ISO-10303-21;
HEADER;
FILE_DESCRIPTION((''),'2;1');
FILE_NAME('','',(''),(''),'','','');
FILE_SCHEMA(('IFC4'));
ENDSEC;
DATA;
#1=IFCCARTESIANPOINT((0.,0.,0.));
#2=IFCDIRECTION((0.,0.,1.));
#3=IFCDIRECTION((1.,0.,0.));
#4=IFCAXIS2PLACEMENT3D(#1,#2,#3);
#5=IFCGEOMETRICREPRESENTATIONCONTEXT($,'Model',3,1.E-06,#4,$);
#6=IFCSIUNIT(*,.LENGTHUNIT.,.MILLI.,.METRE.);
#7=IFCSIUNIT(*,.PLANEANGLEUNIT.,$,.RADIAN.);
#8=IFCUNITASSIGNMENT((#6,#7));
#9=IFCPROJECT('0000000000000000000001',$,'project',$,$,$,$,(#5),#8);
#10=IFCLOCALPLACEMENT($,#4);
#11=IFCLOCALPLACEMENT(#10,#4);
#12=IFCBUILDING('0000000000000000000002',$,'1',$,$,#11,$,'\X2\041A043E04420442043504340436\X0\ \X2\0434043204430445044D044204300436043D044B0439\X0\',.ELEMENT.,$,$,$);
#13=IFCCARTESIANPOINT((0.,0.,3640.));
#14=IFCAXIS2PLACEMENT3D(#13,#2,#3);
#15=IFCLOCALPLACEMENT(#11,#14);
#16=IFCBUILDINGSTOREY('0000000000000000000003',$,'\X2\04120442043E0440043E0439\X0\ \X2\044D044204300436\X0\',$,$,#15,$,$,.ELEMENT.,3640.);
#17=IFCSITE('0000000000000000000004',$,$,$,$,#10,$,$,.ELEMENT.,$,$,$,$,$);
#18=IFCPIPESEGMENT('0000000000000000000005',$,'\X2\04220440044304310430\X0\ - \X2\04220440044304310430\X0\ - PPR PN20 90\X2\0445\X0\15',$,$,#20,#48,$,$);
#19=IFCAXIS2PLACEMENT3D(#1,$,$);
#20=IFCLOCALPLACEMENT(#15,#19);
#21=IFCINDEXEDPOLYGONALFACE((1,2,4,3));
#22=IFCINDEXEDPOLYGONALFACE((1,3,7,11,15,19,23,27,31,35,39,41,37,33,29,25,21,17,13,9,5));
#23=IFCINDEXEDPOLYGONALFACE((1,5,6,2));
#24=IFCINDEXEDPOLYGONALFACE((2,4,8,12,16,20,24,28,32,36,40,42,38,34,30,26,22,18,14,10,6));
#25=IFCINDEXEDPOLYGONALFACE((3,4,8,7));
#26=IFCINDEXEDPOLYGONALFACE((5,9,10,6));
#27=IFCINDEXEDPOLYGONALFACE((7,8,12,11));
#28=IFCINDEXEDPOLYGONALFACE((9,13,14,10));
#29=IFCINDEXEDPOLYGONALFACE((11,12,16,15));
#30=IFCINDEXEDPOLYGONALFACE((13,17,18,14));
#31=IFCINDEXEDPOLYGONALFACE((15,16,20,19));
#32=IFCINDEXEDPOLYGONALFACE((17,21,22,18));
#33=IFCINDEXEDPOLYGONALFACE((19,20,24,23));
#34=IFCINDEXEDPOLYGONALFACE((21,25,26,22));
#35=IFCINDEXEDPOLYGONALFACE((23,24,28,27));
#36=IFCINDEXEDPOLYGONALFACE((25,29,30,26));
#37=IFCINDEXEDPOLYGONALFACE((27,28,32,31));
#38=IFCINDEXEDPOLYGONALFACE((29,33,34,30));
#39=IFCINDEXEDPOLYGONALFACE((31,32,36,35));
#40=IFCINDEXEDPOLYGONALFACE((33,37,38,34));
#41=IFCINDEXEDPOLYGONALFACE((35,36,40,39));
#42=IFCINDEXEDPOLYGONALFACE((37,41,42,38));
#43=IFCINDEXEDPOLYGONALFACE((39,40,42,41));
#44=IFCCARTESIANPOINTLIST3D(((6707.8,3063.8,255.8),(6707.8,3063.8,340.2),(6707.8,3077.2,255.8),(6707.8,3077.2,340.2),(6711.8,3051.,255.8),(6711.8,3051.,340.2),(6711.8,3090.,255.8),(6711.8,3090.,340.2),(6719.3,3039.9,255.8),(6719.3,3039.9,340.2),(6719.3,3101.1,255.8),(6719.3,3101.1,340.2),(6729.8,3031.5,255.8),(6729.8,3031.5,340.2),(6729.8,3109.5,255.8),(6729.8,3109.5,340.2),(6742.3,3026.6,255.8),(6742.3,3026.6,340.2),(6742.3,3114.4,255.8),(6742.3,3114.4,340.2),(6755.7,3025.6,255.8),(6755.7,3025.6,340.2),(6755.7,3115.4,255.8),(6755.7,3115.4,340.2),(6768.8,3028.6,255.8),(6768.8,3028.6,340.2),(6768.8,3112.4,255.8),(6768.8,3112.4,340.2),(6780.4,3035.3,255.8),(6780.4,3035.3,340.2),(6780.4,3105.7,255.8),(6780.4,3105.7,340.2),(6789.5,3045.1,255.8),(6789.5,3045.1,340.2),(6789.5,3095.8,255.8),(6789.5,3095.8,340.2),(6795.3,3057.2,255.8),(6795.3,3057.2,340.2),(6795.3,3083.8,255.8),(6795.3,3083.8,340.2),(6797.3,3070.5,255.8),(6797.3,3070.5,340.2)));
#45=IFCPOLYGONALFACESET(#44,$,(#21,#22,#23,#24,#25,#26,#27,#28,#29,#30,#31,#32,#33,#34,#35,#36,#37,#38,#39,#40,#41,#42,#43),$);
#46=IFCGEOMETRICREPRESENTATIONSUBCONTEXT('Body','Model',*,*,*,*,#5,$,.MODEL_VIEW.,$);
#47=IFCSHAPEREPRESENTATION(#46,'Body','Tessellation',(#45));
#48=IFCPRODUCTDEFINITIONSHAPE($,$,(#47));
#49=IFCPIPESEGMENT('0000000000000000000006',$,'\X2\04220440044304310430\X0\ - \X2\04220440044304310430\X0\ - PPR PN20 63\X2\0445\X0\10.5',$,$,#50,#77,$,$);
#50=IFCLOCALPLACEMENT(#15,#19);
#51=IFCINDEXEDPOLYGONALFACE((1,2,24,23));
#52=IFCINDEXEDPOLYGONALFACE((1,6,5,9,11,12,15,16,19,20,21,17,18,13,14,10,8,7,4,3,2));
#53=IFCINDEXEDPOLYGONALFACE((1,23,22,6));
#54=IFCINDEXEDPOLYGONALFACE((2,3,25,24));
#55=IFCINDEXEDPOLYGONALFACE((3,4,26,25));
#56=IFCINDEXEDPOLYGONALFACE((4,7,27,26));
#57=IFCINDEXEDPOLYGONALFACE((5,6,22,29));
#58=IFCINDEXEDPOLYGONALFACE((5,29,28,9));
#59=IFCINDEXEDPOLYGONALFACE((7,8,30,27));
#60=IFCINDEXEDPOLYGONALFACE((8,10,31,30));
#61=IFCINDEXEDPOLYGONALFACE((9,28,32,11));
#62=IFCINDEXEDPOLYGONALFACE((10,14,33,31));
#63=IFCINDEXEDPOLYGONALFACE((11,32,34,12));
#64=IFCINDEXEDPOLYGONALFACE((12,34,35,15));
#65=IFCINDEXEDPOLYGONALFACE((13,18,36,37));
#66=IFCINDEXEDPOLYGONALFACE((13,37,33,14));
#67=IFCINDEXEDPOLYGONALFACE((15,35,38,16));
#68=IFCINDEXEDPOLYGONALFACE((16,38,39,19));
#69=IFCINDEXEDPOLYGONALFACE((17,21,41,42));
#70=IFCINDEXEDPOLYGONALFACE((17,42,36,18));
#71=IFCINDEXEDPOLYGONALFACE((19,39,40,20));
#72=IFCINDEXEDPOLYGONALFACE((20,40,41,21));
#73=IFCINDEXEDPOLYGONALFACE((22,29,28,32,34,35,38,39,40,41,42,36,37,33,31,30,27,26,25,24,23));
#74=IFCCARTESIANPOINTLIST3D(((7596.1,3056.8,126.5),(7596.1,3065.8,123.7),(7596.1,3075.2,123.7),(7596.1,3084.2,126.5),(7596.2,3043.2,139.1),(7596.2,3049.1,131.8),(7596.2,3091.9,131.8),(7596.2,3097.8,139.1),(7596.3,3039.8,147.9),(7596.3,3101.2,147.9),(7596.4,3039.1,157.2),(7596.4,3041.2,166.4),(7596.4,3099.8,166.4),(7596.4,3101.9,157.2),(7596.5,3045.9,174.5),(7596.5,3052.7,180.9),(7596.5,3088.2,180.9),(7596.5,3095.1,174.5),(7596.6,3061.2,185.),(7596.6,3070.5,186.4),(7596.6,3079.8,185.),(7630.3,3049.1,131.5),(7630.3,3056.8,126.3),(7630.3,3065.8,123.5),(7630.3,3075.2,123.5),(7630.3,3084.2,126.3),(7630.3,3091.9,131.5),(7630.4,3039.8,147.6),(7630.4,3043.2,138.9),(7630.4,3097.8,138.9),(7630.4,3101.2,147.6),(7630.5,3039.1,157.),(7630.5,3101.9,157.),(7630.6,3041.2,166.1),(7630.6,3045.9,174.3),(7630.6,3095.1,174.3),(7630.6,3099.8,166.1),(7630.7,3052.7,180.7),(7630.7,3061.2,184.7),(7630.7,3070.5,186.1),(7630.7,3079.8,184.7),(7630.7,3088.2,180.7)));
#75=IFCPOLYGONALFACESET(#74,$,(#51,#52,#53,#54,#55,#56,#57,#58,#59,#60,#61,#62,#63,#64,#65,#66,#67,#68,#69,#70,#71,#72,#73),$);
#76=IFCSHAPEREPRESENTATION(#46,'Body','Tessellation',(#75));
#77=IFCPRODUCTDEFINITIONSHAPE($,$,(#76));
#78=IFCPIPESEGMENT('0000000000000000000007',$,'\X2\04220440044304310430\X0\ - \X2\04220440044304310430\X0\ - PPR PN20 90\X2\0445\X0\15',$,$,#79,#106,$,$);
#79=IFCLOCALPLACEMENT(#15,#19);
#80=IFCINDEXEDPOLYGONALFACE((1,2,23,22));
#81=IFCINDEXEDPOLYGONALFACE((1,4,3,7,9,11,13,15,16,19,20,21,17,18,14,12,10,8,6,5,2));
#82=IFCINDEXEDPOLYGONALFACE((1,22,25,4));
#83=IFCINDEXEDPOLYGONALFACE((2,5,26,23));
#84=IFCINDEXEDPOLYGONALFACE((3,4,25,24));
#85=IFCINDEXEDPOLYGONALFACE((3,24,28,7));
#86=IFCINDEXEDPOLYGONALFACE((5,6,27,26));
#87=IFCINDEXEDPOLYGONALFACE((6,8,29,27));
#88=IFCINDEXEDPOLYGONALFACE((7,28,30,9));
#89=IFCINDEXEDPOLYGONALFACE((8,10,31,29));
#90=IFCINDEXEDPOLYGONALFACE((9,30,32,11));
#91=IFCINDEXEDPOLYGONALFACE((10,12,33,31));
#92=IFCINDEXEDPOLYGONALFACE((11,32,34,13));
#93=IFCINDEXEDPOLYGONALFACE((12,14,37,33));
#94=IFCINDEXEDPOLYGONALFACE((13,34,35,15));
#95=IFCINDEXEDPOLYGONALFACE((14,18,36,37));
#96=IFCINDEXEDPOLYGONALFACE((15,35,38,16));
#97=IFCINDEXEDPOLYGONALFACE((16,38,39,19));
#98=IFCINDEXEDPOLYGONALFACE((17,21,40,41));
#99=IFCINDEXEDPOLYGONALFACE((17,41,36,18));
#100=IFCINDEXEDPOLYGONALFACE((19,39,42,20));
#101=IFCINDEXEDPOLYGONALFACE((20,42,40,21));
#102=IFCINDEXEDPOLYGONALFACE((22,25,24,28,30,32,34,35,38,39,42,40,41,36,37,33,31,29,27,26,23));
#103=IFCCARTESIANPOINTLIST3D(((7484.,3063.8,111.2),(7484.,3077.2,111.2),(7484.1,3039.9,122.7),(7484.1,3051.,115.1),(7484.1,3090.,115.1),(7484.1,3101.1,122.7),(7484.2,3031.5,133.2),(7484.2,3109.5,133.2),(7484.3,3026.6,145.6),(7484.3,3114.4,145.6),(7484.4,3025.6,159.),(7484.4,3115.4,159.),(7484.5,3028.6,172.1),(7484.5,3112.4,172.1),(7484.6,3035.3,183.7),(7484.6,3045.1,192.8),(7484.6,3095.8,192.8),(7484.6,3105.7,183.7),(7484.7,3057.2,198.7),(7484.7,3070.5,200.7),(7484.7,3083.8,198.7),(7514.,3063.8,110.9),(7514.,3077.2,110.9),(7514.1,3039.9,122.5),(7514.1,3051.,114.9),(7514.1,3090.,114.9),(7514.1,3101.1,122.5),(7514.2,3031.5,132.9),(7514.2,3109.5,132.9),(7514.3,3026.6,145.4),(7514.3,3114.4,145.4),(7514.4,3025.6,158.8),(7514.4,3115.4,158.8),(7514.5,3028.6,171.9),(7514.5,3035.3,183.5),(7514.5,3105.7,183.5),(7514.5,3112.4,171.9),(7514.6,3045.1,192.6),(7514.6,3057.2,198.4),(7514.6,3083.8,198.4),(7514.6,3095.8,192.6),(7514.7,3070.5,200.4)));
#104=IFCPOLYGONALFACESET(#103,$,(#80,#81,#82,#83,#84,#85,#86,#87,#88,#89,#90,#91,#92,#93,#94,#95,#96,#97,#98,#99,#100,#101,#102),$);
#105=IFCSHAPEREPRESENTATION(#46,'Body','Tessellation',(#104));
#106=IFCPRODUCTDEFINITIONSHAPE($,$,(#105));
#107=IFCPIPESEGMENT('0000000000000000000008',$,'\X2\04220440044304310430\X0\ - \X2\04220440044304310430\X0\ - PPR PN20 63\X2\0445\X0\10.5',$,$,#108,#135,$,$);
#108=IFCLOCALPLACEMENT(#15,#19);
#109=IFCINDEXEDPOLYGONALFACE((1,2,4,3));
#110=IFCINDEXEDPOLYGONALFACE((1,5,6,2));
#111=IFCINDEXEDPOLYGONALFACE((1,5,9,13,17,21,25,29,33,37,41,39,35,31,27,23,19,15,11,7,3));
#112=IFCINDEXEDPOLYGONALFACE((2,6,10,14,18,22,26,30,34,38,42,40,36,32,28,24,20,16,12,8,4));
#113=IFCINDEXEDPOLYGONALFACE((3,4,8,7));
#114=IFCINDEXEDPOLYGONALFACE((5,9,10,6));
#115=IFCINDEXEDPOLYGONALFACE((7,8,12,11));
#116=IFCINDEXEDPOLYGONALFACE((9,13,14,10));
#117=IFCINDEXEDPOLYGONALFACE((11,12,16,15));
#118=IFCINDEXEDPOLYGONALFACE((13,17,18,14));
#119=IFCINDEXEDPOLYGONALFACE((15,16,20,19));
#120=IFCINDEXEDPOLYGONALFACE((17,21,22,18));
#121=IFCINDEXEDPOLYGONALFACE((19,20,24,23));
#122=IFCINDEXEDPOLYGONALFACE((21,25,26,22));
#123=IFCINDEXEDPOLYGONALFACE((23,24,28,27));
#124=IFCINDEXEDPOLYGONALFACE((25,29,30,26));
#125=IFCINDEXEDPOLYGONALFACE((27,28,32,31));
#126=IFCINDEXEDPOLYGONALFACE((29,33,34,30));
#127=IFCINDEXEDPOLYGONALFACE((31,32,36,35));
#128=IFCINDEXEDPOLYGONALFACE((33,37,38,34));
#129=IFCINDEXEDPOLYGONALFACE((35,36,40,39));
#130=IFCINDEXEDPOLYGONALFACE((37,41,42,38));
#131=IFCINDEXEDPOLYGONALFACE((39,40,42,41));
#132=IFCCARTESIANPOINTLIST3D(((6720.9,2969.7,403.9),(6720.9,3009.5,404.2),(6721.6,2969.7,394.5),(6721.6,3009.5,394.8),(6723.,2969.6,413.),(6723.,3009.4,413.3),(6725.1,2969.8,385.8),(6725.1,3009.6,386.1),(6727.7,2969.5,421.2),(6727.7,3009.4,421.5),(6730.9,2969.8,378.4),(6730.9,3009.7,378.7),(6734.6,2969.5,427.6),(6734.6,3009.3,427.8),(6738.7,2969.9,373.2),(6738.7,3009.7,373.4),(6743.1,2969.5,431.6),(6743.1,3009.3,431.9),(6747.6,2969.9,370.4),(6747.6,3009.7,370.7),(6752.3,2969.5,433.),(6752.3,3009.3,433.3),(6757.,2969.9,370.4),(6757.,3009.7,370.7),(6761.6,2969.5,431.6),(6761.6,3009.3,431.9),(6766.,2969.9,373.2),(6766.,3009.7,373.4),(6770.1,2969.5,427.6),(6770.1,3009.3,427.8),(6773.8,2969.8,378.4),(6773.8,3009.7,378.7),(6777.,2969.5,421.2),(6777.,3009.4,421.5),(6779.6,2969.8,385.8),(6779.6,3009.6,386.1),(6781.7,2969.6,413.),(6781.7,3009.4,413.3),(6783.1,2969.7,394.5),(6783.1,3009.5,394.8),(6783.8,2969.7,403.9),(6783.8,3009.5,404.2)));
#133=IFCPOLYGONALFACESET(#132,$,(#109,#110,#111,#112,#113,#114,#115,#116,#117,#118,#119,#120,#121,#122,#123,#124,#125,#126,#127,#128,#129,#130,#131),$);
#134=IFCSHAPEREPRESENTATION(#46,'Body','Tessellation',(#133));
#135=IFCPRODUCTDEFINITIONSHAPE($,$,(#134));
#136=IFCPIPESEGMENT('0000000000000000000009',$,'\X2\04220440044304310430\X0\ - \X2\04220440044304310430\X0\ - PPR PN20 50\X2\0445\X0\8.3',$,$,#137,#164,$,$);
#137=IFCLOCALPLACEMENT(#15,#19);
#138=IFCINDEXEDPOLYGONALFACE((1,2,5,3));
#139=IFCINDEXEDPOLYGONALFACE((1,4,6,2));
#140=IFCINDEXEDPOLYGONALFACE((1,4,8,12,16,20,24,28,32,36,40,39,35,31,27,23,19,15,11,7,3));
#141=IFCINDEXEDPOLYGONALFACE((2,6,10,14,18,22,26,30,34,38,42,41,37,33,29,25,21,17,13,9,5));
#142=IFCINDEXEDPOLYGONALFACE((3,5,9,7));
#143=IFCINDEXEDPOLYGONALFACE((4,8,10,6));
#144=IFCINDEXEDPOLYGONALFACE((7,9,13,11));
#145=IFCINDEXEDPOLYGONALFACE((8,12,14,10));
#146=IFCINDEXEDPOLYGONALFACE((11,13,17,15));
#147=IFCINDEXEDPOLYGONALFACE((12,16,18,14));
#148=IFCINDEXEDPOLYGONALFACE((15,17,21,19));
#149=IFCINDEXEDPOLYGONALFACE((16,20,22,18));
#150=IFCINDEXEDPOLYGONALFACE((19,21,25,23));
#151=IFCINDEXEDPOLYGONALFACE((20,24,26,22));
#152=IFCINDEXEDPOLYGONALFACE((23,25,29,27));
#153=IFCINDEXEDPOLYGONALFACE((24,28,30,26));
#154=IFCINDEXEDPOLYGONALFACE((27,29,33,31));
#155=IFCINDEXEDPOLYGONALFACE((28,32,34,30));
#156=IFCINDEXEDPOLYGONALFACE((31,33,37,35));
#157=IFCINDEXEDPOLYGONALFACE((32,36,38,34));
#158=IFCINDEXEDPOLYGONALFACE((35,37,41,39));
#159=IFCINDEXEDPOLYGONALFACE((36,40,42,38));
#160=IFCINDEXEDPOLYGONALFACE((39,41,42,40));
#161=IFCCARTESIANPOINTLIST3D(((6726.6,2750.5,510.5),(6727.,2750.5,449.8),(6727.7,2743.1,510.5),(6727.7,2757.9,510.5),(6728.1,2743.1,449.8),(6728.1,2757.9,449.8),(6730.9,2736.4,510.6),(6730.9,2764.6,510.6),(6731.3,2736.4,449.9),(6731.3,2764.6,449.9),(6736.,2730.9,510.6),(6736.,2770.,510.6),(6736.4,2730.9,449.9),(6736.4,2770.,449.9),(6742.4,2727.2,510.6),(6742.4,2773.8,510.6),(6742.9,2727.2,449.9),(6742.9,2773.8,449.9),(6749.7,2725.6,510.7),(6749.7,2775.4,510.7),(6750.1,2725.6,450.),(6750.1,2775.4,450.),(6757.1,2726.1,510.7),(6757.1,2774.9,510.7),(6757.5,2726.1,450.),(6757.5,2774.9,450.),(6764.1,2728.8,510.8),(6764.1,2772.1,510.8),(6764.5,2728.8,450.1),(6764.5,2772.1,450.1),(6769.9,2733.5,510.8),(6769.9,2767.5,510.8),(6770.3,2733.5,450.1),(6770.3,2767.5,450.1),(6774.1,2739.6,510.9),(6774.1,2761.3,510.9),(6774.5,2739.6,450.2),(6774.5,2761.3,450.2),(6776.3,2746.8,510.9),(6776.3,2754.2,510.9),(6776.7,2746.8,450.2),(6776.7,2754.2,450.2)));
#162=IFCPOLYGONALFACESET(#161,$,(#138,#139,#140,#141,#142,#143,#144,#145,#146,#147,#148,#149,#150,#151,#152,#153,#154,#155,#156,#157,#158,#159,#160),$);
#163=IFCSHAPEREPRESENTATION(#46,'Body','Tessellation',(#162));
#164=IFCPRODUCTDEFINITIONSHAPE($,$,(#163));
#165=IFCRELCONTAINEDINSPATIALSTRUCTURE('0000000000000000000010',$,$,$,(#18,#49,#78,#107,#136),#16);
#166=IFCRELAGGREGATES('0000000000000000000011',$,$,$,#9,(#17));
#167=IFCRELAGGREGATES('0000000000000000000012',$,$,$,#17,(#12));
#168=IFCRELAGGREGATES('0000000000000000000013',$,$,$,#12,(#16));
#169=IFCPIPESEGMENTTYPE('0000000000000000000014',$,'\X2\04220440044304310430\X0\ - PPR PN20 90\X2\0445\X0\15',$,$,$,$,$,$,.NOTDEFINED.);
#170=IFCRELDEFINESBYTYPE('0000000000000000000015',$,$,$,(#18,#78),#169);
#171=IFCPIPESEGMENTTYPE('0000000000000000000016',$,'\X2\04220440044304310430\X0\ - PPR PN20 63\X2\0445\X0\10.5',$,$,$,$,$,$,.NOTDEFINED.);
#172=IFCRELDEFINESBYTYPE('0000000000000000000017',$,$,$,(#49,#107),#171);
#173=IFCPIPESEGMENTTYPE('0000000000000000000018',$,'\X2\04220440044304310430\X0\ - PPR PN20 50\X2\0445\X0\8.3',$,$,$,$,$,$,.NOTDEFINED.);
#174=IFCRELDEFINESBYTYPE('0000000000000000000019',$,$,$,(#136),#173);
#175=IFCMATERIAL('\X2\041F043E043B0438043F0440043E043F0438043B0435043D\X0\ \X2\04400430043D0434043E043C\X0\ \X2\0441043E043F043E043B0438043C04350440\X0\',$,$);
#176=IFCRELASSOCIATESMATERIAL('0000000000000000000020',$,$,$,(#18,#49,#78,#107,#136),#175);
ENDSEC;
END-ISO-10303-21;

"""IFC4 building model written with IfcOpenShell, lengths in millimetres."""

from ifc_helpers import new_model, entity, si_unit, frame, origin_with_axes, place, context, subcontext, project, spatial, source, transform, mapped, material, type_object, element, save


model = new_model("IFC4")

# Units and contexts
model_context = context("Model", 3, precision=1e-06, world=origin_with_axes())
body_context = subcontext(model_context, "Body", "Model", "MODEL_VIEW")
ifc_project = project(units=[si_unit("LENGTHUNIT", "METRE", prefix="MILLI"), si_unit("PLANEANGLEUNIT", "RADIAN")], contexts=[model_context])

# Site, building, storey
site_placement = place(None, origin_with_axes())
site = spatial("IfcSite", under=ifc_project, at=site_placement, CompositionType="ELEMENT")
building_placement = place(site_placement, origin_with_axes())
building = spatial("IfcBuilding", under=site, at=building_placement, Name="1", LongName="Коттедж двухэтажный", CompositionType="ELEMENT")
storey_placement = place(building_placement, frame((0.0, 0.0, 3640.0), z_axis=(0.0, 0.0, 1.0), x_axis=(1.0, 0.0, 0.0)))
storey = spatial("IfcBuildingStorey", under=building, at=storey_placement, Name="Второй этаж", CompositionType="ELEMENT", Elevation=3640.0)

# Pipe segments
ifc_material = material(Name="Полипропилен рандом сополимер")
pipe_segment_type_1 = type_object("IfcPipeSegmentType", Name="Труба - PPR PN20 63х10.5", PredefinedType="NOTDEFINED")
pipe_segment_type_2 = type_object("IfcPipeSegmentType", Name="Труба - PPR PN20 50х8.3", PredefinedType="NOTDEFINED")
pipe_segment_type_3 = type_object("IfcPipeSegmentType", Name="Труба - PPR PN20 90х15", PredefinedType="NOTDEFINED")
shared_shape_1 = source(origin_with_axes(), body_context, "Body", "AdvancedSweptSolid", [
    entity("IfcSweptDiskSolid", entity("IfcIndexedPolyCurve", entity("IfcCartesianPointList3D", [[0.0, 0.0, 0.0], [0.0, 0.0, 84.5]]), [entity("IfcLineIndex", [1, 2])]), 45.0),
])
pipe_segment_1_placement = place(storey_placement, frame((6752.3, 3070.5, 340.2), z_axis=(0.0, 0.0, -1.0), x_axis=(1.0, 0.0, 0.0)))
element("IfcPipeSegment", 1, at=pipe_segment_1_placement, inside=storey, type_object=pipe_segment_type_3, material=ifc_material, Name="Труба - Труба - PPR PN20 90х15", context=body_context, shape_type="MappedRepresentation", body=[
    mapped(shared_shape_1, transform((0.0, 0.0, 0.0), x_axis=(1.0, 0.0, 0.0), y_axis=(0.0, 1.0, 0.0), z_axis=(0.0, 0.0, 1.0), scale=1.0)),
])
shared_shape_2 = source(origin_with_axes(), body_context, "Body", "AdvancedSweptSolid", [
    entity("IfcSweptDiskSolid", entity("IfcIndexedPolyCurve", entity("IfcCartesianPointList3D", [[0.0, 0.0, 0.0], [34.1, 0.0, 0.2]]), [entity("IfcLineIndex", [1, 2])]), 31.5),
])
pipe_segment_2_placement = place(storey_placement, frame((7630.5, 3070.5, 154.6), z_axis=(0.0, 0.0, 1.0), x_axis=(-1.0, 0.0, 0.0)))
element("IfcPipeSegment", 2, at=pipe_segment_2_placement, inside=storey, type_object=pipe_segment_type_1, material=ifc_material, Name="Труба - Труба - PPR PN20 63х10.5", context=body_context, shape_type="MappedRepresentation", body=[
    mapped(shared_shape_2, transform((0.0, 0.0, 0.0), x_axis=(1.0, 0.0, 0.0), y_axis=(0.0, 1.0, 0.0), z_axis=(0.0, 0.0, 1.0), scale=1.0)),
])
shared_shape_3 = source(origin_with_axes(), body_context, "Body", "AdvancedSweptSolid", [
    entity("IfcSweptDiskSolid", entity("IfcIndexedPolyCurve", entity("IfcCartesianPointList3D", [[0.0, 0.0, 0.0], [30.0, 0.0, 0.2]]), [entity("IfcLineIndex", [1, 2])]), 45.0),
])
pipe_segment_3_placement = place(storey_placement, frame((7514.3, 3070.5, 155.4), z_axis=(0.0, 0.0, 1.0), x_axis=(-1.0, 0.0, 0.0)))
element("IfcPipeSegment", 3, at=pipe_segment_3_placement, inside=storey, type_object=pipe_segment_type_3, material=ifc_material, Name="Труба - Труба - PPR PN20 90х15", context=body_context, shape_type="MappedRepresentation", body=[
    mapped(shared_shape_3, transform((0.0, 0.0, 0.0), x_axis=(1.0, 0.0, 0.0), y_axis=(0.0, 1.0, 0.0), z_axis=(0.0, 0.0, 1.0), scale=1.0)),
])
shared_shape_4 = source(origin_with_axes(), body_context, "Body", "AdvancedSweptSolid", [
    entity("IfcSweptDiskSolid", entity("IfcIndexedPolyCurve", entity("IfcCartesianPointList3D", [[0.0, 0.0, 0.0], [39.8, 0.0, 0.3]]), [entity("IfcLineIndex", [1, 2])]), 31.5),
])
pipe_segment_4_placement = place(storey_placement, frame((6752.3, 2969.7, 401.5), z_axis=(0.0, 0.0, 1.0), x_axis=(0.0, 1.0, 0.0)))
element("IfcPipeSegment", 4, at=pipe_segment_4_placement, inside=storey, type_object=pipe_segment_type_1, material=ifc_material, Name="Труба - Труба - PPR PN20 63х10.5", context=body_context, shape_type="MappedRepresentation", body=[
    mapped(shared_shape_4, transform((0.0, 0.0, 0.0), x_axis=(1.0, 0.0, 0.0), y_axis=(0.0, 1.0, 0.0), z_axis=(0.0, 0.0, 1.0), scale=1.0)),
])
shared_shape_5 = source(origin_with_axes(), body_context, "Body", "AdvancedSweptSolid", [
    entity("IfcSweptDiskSolid", entity("IfcIndexedPolyCurve", entity("IfcCartesianPointList3D", [[0.0, 0.0, 0.0], [0.4, 0.0, -60.7]]), [entity("IfcLineIndex", [1, 2])]), 25.0),
])
pipe_segment_5_placement = place(storey_placement, frame((6751.6, 2750.5, 510.7), z_axis=(0.0, 0.0, 1.0), x_axis=(1.0, 0.0, 0.0)))
element("IfcPipeSegment", 5, at=pipe_segment_5_placement, inside=storey, type_object=pipe_segment_type_2, material=ifc_material, Name="Труба - Труба - PPR PN20 50х8.3", context=body_context, shape_type="MappedRepresentation", body=[
    mapped(shared_shape_5, transform((0.0, 0.0, 0.0), x_axis=(1.0, 0.0, 0.0), y_axis=(0.0, 1.0, 0.0), z_axis=(0.0, 0.0, 1.0), scale=1.0)),
])

save(model, "model.ifc")
